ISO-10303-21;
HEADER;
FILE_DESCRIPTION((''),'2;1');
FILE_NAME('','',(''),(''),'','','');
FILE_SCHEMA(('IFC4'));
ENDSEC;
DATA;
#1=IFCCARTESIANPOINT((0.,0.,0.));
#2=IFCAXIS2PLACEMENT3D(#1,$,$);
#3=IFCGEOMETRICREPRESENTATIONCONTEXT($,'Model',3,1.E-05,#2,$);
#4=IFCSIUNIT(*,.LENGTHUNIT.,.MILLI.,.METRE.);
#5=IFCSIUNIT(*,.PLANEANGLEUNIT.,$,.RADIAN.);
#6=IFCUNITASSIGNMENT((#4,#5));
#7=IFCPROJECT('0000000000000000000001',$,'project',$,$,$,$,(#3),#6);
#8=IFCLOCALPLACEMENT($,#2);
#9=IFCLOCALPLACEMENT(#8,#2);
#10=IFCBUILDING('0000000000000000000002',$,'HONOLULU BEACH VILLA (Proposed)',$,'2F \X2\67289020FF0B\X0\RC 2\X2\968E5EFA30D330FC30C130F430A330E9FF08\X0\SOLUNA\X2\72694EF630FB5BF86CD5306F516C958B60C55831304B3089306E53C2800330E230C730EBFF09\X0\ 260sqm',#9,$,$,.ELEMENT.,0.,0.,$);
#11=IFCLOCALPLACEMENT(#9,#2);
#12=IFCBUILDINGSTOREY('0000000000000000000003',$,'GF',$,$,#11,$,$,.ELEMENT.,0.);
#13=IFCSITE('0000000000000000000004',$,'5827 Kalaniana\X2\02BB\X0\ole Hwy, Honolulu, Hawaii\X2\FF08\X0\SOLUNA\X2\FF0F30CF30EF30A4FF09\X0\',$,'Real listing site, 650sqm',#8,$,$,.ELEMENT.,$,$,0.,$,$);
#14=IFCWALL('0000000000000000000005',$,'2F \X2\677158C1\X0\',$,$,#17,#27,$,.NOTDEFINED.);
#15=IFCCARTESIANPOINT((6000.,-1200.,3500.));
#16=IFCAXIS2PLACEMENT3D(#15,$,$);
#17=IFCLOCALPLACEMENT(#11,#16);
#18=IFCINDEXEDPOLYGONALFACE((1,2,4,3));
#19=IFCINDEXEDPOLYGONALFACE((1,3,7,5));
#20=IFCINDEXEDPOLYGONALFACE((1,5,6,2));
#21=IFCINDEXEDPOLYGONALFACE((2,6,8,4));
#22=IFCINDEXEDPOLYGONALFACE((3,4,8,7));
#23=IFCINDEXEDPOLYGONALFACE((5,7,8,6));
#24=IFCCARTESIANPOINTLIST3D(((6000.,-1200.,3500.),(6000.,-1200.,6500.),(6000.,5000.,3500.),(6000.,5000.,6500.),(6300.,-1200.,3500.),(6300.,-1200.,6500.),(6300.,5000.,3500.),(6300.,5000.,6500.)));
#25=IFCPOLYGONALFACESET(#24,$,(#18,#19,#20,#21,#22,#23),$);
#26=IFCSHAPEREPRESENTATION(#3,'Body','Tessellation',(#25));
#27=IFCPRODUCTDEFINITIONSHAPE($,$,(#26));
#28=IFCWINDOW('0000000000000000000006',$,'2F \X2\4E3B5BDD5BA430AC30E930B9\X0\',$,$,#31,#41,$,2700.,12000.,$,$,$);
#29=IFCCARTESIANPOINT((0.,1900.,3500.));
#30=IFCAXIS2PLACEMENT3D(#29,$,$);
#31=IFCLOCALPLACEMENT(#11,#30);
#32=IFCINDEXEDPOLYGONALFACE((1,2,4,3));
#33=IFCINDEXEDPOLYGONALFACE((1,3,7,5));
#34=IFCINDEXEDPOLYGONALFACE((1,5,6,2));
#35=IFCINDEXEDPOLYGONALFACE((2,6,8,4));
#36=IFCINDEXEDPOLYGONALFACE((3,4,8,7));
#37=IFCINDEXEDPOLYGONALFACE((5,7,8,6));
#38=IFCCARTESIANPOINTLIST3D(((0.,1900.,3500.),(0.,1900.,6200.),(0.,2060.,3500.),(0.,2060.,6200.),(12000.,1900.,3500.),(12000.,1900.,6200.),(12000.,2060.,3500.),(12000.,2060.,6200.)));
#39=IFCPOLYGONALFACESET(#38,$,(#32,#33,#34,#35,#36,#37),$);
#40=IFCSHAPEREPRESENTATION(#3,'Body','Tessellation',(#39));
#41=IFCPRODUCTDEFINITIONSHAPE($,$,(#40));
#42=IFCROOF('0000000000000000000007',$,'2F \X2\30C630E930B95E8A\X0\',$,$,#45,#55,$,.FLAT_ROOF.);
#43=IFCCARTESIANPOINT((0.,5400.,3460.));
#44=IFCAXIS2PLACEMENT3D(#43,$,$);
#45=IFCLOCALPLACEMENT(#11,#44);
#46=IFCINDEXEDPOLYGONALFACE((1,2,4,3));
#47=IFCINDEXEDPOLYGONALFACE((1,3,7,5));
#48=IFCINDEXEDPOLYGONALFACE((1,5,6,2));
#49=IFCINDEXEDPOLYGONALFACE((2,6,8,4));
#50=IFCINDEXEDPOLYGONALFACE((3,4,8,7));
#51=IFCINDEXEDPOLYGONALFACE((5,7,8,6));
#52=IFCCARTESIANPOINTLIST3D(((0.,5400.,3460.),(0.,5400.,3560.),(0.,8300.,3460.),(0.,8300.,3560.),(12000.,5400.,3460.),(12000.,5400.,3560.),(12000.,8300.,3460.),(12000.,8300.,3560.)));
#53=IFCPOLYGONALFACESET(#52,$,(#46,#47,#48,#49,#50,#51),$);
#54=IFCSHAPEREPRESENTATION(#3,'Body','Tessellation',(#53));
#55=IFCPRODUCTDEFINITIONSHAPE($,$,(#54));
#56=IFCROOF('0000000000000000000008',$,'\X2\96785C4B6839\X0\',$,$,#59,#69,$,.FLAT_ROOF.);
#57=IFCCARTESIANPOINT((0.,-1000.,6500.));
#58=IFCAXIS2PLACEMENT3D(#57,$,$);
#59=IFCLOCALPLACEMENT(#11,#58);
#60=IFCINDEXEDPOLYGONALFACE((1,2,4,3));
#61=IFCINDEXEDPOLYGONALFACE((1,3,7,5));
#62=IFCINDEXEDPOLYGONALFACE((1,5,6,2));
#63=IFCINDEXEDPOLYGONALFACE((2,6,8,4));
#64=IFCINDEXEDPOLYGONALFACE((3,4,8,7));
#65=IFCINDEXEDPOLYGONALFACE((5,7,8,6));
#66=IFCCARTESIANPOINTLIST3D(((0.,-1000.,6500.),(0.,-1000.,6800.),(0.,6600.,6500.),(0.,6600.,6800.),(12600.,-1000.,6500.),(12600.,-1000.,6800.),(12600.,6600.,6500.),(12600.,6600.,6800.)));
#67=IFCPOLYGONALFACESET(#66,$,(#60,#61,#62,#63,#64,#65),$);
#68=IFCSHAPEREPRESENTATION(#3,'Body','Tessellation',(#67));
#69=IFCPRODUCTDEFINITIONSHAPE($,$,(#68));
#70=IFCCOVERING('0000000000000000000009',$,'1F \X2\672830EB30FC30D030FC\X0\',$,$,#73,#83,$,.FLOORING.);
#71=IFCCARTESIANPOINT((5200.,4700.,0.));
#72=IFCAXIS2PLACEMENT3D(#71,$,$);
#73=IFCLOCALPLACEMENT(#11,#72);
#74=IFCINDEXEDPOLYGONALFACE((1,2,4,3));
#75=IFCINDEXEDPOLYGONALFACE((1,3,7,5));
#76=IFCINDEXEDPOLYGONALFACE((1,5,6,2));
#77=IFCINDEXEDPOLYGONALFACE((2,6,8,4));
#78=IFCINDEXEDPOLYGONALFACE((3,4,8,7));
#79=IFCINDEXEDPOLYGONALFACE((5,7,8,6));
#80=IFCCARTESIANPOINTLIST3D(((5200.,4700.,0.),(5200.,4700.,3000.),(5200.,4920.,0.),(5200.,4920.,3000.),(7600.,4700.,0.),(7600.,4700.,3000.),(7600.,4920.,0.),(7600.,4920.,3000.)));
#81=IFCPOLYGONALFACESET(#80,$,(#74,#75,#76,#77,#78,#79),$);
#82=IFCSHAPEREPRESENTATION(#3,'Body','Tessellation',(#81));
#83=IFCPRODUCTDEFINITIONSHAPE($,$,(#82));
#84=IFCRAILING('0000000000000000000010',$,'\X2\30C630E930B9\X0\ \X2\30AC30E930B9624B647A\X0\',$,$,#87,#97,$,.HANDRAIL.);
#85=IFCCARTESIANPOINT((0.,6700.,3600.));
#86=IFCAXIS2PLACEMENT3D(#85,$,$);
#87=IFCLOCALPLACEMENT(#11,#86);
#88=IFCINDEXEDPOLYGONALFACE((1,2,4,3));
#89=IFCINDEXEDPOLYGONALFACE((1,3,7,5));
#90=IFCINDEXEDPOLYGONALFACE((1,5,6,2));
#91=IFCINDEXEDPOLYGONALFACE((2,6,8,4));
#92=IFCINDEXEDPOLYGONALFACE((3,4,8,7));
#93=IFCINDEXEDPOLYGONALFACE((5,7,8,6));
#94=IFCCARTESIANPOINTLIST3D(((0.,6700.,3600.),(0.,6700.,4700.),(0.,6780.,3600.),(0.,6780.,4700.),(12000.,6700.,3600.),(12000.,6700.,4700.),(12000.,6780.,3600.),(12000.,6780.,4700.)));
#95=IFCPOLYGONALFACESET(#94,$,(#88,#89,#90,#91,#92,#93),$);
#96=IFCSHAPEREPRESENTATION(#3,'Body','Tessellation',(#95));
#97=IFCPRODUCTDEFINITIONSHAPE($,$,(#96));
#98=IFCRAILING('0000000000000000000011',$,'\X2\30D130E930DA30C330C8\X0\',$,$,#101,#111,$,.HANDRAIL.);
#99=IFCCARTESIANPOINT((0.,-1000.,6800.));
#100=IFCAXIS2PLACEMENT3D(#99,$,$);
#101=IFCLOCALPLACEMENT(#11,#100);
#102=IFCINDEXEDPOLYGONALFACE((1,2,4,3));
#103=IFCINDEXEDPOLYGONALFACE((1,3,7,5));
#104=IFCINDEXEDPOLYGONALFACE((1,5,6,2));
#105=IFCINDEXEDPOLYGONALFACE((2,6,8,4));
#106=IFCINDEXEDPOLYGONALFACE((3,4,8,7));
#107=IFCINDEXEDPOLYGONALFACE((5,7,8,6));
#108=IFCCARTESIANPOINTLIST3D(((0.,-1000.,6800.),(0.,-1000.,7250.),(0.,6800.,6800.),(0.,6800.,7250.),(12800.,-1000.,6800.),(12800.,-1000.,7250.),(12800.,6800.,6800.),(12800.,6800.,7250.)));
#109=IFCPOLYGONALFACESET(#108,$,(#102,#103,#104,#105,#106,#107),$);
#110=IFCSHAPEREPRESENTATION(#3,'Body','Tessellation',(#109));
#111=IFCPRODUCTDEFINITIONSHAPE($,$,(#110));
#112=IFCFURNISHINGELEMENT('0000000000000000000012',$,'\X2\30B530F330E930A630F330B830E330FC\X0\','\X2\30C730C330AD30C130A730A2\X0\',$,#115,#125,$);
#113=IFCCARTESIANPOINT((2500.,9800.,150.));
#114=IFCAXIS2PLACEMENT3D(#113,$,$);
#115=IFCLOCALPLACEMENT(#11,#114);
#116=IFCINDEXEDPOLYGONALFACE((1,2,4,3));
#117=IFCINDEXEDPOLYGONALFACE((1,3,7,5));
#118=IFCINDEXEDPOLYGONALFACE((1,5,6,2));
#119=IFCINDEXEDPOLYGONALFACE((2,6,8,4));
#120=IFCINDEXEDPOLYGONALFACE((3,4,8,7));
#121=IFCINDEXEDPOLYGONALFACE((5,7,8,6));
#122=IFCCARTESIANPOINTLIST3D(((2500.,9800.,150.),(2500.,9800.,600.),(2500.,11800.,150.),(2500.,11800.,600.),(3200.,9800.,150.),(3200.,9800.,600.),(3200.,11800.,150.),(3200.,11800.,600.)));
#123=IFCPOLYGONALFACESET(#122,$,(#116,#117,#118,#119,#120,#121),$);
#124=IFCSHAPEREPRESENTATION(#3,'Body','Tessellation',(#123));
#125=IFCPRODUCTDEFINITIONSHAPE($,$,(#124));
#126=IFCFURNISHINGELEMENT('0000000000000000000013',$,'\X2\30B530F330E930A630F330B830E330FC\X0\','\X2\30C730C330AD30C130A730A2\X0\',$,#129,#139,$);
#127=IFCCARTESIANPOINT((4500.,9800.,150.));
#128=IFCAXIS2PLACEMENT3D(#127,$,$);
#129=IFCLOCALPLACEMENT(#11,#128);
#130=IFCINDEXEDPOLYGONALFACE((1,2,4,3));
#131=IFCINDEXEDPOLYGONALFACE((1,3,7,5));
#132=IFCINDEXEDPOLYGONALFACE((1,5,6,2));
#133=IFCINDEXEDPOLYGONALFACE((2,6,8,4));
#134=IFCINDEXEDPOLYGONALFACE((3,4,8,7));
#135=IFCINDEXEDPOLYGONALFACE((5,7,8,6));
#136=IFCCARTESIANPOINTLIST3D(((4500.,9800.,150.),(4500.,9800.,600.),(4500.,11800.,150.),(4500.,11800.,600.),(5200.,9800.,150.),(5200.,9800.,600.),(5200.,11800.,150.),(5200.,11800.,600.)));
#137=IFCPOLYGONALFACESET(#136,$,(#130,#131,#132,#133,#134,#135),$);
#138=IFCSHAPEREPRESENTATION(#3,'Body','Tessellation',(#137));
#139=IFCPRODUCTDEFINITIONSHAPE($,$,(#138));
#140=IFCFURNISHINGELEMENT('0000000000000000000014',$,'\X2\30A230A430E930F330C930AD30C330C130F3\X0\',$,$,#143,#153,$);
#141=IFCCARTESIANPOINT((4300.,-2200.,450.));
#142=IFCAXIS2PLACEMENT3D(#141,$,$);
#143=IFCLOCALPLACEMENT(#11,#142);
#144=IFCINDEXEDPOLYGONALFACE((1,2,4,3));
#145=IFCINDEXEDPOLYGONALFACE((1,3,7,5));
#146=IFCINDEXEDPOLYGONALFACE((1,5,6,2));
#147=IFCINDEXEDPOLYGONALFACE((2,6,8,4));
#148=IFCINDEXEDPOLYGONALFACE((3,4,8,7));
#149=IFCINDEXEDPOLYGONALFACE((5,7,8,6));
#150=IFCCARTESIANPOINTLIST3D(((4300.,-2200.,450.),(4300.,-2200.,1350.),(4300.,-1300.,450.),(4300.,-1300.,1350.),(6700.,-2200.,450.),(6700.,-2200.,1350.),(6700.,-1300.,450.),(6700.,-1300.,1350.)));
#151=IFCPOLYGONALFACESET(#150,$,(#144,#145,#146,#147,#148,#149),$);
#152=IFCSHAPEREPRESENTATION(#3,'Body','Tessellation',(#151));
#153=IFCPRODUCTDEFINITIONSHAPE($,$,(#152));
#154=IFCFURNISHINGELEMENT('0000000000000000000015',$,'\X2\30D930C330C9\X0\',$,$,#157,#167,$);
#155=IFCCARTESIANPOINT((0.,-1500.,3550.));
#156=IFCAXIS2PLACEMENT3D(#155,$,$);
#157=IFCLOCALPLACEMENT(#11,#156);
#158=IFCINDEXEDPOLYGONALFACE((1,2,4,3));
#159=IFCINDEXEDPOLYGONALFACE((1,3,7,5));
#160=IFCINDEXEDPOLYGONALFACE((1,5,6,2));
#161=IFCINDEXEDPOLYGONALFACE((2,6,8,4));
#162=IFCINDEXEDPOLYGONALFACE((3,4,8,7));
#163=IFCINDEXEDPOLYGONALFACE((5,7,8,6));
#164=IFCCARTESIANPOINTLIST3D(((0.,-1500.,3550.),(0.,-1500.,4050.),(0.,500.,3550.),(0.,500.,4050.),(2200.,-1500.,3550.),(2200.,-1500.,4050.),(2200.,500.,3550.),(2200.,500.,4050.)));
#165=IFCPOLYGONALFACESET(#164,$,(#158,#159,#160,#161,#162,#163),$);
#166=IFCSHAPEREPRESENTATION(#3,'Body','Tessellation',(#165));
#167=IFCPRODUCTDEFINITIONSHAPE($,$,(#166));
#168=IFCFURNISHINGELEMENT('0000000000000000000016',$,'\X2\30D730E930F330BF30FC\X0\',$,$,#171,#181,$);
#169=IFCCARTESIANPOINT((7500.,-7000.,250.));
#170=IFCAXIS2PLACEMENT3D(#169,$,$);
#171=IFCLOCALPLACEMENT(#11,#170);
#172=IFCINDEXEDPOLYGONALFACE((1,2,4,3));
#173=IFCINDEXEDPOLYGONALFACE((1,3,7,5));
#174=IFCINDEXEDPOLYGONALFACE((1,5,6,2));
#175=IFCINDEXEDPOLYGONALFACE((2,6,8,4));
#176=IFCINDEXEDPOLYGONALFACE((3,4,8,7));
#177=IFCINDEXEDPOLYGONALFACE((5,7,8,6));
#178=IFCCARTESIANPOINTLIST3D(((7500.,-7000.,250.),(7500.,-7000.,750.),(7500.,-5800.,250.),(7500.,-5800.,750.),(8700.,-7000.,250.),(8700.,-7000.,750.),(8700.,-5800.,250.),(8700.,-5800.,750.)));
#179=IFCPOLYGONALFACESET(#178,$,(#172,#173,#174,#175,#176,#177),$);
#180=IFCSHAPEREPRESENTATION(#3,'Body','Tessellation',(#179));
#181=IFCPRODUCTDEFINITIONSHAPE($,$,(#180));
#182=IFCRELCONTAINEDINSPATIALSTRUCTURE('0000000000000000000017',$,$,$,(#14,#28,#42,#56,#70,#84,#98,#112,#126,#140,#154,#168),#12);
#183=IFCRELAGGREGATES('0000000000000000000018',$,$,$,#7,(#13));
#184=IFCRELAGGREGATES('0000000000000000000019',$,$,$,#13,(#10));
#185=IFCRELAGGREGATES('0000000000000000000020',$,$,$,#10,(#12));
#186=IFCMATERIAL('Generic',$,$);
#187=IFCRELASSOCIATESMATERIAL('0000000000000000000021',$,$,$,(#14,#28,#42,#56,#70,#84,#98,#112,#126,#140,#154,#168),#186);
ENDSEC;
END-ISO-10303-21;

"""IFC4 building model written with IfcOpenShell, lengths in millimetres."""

from ifc_helpers import new_model, si_unit, frame, frame_2d, origin, place, context, project, spatial, rectangle, extrude, material, element, fill, save


model = new_model("IFC4")

# Units and contexts
model_context = context("Model", 3, precision=1e-05, world=origin())
ifc_project = project(units=[si_unit("LENGTHUNIT", "METRE", prefix="MILLI"), si_unit("PLANEANGLEUNIT", "RADIAN")], contexts=[model_context])

# Site, building, storey
site_placement = place(None, origin())
site = spatial("IfcSite", under=ifc_project, at=site_placement, Name="5827 Kalanianaʻole Hwy, Honolulu, Hawaii（SOLUNA／ハワイ）", ObjectType="Real listing site, 650sqm", CompositionType="ELEMENT", RefElevation=0.0)
building_placement = place(site_placement, origin())
building = spatial("IfcBuilding", under=site, at=building_placement, Name="HONOLULU BEACH VILLA (Proposed)", ObjectType="2F 木造＋RC 2階建ビーチヴィラ（SOLUNA物件・寸法は公開情報からの参考モデル） 260sqm", CompositionType="ELEMENT", ElevationOfRefHeight=0.0, ElevationOfTerrain=0.0)
storey_placement = place(building_placement, origin())
storey = spatial("IfcBuildingStorey", under=building, at=storey_placement, Name="GF", CompositionType="ELEMENT", Elevation=0.0)

# Shared definitions
ifc_material_1 = material(Name="Generic")

# Wall, opening, window
wall_1_placement = place(storey_placement, frame((6000.0, -1200.0, 3500.0)))
wall_1 = element("IfcWall", 1, at=wall_1_placement, inside=storey, material=ifc_material_1, Name="2F 東壁", PredefinedType="NOTDEFINED", context=model_context, shape_type="SweptSolid", body=[
    extrude(rectangle(XDim=300.0, YDim=6200.0, at=frame_2d((150.0, 3100.0))), frame((6000.0, -1200.0, 3500.0)), (0.0, 0.0, 1.0), 3000.0),
])
opening_1_placement = place(storey_placement, frame((0.0, 1900.0, 3500.0)))
opening_1 = element("IfcOpeningElement", 2, at=opening_1_placement, cuts=wall_1, PredefinedType="NOTDEFINED", context=model_context, shape_type="SweptSolid", body=[
    extrude(rectangle(XDim=12000.0, YDim=160.0, at=frame_2d((6000.0, 80.0))), frame((0.0, 1900.0, 3500.0)), (0.0, 0.0, 1.0), 2700.0),
])
window_1_placement = place(storey_placement, frame((0.0, 1900.0, 3500.0)))
window_1 = element("IfcWindow", 3, at=window_1_placement, inside=storey, material=ifc_material_1, Name="2F 主寝室ガラス", OverallHeight=2700.0, OverallWidth=12000.0, context=model_context, shape_type="SweptSolid", body=[
    extrude(rectangle(XDim=12000.0, YDim=160.0, at=frame_2d((6000.0, 80.0))), frame((0.0, 1900.0, 3500.0)), (0.0, 0.0, 1.0), 2700.0),
])
fill(opening_1, window_1)

# Roofs
roof_1_placement = place(storey_placement, frame((0.0, 5400.0, 3460.0)))
element("IfcRoof", 4, at=roof_1_placement, inside=storey, material=ifc_material_1, Name="2F テラス床", PredefinedType="FLAT_ROOF", context=model_context, shape_type="SweptSolid", body=[
    extrude(rectangle(XDim=12000.0, YDim=2900.0, at=frame_2d((6000.0, 1450.0))), frame((0.0, 5400.0, 3460.0)), (0.0, 0.0, 1.0), 100.0),
])
roof_2_placement = place(storey_placement, frame((0.0, -1000.0, 6500.0)))
element("IfcRoof", 5, at=roof_2_placement, inside=storey, material=ifc_material_1, Name="陸屋根", PredefinedType="FLAT_ROOF", context=model_context, shape_type="SweptSolid", body=[
    extrude(rectangle(XDim=12600.0, YDim=7600.0, at=frame_2d((6300.0, 3800.0))), frame((0.0, -1000.0, 6500.0)), (0.0, 0.0, 1.0), 300.0),
])

# Covering
covering_placement = place(storey_placement, frame((5200.0, 4700.0, 0.0)))
element("IfcCovering", 6, at=covering_placement, inside=storey, material=ifc_material_1, Name="1F 木ルーバー", PredefinedType="FLOORING", context=model_context, shape_type="SweptSolid", body=[
    extrude(rectangle(XDim=2400.0, YDim=220.0, at=frame_2d((1200.0, 110.0))), frame((5200.0, 4700.0, 0.0)), (0.0, 0.0, 1.0), 3000.0),
])

# Railings
railing_1_placement = place(storey_placement, frame((0.0, 6700.0, 3600.0)))
element("IfcRailing", 7, at=railing_1_placement, inside=storey, material=ifc_material_1, Name="テラス ガラス手摺", PredefinedType="HANDRAIL", context=model_context, shape_type="SweptSolid", body=[
    extrude(rectangle(XDim=12000.0, YDim=80.0, at=frame_2d((6000.0, 40.0))), frame((0.0, 6700.0, 3600.0)), (0.0, 0.0, 1.0), 1100.0),
])
railing_2_placement = place(storey_placement, frame((0.0, -1000.0, 6800.0)))
element("IfcRailing", 8, at=railing_2_placement, inside=storey, material=ifc_material_1, Name="パラペット", PredefinedType="HANDRAIL", context=model_context, shape_type="SweptSolid", body=[
    extrude(rectangle(XDim=12800.0, YDim=7800.0, at=frame_2d((6400.0, 3900.0))), frame((0.0, -1000.0, 6800.0)), (0.0, 0.0, 1.0), 450.0),
])

# Furnishing elements
furnishing_1_placement = place(storey_placement, frame((2500.0, 9800.0, 150.0)))
element("IfcFurnishingElement", 9, at=furnishing_1_placement, inside=storey, material=ifc_material_1, Name="サンラウンジャー", Description="デッキチェア", context=model_context, shape_type="SweptSolid", body=[
    extrude(rectangle(XDim=700.0, YDim=2000.0, at=frame_2d((350.0, 1000.0))), frame((2500.0, 9800.0, 150.0)), (0.0, 0.0, 1.0), 450.0),
])
furnishing_2_placement = place(storey_placement, frame((4500.0, 9800.0, 150.0)))
element("IfcFurnishingElement", 10, at=furnishing_2_placement, inside=storey, material=ifc_material_1, Name="サンラウンジャー", Description="デッキチェア", context=model_context, shape_type="SweptSolid", body=[
    extrude(rectangle(XDim=700.0, YDim=2000.0, at=frame_2d((350.0, 1000.0))), frame((4500.0, 9800.0, 150.0)), (0.0, 0.0, 1.0), 450.0),
])
furnishing_3_placement = place(storey_placement, frame((4300.0, -2200.0, 450.0)))
element("IfcFurnishingElement", 11, at=furnishing_3_placement, inside=storey, material=ifc_material_1, Name="アイランドキッチン", context=model_context, shape_type="SweptSolid", body=[
    extrude(rectangle(XDim=2400.0, YDim=900.0, at=frame_2d((1200.0, 450.0))), frame((4300.0, -2200.0, 450.0)), (0.0, 0.0, 1.0), 900.0),
])
furnishing_4_placement = place(storey_placement, frame((0.0, -1500.0, 3550.0)))
element("IfcFurnishingElement", 12, at=furnishing_4_placement, inside=storey, material=ifc_material_1, Name="ベッド", context=model_context, shape_type="SweptSolid", body=[
    extrude(rectangle(XDim=2200.0, YDim=2000.0, at=frame_2d((1100.0, 1000.0))), frame((0.0, -1500.0, 3550.0)), (0.0, 0.0, 1.0), 500.0),
])
furnishing_5_placement = place(storey_placement, frame((7500.0, -7000.0, 250.0)))
element("IfcFurnishingElement", 13, at=furnishing_5_placement, inside=storey, material=ifc_material_1, Name="プランター", context=model_context, shape_type="SweptSolid", body=[
    extrude(rectangle(XDim=1200.0, YDim=1200.0, at=frame_2d((600.0, 600.0))), frame((7500.0, -7000.0, 250.0)), (0.0, 0.0, 1.0), 500.0),
])

save(model, "model.ifc")
